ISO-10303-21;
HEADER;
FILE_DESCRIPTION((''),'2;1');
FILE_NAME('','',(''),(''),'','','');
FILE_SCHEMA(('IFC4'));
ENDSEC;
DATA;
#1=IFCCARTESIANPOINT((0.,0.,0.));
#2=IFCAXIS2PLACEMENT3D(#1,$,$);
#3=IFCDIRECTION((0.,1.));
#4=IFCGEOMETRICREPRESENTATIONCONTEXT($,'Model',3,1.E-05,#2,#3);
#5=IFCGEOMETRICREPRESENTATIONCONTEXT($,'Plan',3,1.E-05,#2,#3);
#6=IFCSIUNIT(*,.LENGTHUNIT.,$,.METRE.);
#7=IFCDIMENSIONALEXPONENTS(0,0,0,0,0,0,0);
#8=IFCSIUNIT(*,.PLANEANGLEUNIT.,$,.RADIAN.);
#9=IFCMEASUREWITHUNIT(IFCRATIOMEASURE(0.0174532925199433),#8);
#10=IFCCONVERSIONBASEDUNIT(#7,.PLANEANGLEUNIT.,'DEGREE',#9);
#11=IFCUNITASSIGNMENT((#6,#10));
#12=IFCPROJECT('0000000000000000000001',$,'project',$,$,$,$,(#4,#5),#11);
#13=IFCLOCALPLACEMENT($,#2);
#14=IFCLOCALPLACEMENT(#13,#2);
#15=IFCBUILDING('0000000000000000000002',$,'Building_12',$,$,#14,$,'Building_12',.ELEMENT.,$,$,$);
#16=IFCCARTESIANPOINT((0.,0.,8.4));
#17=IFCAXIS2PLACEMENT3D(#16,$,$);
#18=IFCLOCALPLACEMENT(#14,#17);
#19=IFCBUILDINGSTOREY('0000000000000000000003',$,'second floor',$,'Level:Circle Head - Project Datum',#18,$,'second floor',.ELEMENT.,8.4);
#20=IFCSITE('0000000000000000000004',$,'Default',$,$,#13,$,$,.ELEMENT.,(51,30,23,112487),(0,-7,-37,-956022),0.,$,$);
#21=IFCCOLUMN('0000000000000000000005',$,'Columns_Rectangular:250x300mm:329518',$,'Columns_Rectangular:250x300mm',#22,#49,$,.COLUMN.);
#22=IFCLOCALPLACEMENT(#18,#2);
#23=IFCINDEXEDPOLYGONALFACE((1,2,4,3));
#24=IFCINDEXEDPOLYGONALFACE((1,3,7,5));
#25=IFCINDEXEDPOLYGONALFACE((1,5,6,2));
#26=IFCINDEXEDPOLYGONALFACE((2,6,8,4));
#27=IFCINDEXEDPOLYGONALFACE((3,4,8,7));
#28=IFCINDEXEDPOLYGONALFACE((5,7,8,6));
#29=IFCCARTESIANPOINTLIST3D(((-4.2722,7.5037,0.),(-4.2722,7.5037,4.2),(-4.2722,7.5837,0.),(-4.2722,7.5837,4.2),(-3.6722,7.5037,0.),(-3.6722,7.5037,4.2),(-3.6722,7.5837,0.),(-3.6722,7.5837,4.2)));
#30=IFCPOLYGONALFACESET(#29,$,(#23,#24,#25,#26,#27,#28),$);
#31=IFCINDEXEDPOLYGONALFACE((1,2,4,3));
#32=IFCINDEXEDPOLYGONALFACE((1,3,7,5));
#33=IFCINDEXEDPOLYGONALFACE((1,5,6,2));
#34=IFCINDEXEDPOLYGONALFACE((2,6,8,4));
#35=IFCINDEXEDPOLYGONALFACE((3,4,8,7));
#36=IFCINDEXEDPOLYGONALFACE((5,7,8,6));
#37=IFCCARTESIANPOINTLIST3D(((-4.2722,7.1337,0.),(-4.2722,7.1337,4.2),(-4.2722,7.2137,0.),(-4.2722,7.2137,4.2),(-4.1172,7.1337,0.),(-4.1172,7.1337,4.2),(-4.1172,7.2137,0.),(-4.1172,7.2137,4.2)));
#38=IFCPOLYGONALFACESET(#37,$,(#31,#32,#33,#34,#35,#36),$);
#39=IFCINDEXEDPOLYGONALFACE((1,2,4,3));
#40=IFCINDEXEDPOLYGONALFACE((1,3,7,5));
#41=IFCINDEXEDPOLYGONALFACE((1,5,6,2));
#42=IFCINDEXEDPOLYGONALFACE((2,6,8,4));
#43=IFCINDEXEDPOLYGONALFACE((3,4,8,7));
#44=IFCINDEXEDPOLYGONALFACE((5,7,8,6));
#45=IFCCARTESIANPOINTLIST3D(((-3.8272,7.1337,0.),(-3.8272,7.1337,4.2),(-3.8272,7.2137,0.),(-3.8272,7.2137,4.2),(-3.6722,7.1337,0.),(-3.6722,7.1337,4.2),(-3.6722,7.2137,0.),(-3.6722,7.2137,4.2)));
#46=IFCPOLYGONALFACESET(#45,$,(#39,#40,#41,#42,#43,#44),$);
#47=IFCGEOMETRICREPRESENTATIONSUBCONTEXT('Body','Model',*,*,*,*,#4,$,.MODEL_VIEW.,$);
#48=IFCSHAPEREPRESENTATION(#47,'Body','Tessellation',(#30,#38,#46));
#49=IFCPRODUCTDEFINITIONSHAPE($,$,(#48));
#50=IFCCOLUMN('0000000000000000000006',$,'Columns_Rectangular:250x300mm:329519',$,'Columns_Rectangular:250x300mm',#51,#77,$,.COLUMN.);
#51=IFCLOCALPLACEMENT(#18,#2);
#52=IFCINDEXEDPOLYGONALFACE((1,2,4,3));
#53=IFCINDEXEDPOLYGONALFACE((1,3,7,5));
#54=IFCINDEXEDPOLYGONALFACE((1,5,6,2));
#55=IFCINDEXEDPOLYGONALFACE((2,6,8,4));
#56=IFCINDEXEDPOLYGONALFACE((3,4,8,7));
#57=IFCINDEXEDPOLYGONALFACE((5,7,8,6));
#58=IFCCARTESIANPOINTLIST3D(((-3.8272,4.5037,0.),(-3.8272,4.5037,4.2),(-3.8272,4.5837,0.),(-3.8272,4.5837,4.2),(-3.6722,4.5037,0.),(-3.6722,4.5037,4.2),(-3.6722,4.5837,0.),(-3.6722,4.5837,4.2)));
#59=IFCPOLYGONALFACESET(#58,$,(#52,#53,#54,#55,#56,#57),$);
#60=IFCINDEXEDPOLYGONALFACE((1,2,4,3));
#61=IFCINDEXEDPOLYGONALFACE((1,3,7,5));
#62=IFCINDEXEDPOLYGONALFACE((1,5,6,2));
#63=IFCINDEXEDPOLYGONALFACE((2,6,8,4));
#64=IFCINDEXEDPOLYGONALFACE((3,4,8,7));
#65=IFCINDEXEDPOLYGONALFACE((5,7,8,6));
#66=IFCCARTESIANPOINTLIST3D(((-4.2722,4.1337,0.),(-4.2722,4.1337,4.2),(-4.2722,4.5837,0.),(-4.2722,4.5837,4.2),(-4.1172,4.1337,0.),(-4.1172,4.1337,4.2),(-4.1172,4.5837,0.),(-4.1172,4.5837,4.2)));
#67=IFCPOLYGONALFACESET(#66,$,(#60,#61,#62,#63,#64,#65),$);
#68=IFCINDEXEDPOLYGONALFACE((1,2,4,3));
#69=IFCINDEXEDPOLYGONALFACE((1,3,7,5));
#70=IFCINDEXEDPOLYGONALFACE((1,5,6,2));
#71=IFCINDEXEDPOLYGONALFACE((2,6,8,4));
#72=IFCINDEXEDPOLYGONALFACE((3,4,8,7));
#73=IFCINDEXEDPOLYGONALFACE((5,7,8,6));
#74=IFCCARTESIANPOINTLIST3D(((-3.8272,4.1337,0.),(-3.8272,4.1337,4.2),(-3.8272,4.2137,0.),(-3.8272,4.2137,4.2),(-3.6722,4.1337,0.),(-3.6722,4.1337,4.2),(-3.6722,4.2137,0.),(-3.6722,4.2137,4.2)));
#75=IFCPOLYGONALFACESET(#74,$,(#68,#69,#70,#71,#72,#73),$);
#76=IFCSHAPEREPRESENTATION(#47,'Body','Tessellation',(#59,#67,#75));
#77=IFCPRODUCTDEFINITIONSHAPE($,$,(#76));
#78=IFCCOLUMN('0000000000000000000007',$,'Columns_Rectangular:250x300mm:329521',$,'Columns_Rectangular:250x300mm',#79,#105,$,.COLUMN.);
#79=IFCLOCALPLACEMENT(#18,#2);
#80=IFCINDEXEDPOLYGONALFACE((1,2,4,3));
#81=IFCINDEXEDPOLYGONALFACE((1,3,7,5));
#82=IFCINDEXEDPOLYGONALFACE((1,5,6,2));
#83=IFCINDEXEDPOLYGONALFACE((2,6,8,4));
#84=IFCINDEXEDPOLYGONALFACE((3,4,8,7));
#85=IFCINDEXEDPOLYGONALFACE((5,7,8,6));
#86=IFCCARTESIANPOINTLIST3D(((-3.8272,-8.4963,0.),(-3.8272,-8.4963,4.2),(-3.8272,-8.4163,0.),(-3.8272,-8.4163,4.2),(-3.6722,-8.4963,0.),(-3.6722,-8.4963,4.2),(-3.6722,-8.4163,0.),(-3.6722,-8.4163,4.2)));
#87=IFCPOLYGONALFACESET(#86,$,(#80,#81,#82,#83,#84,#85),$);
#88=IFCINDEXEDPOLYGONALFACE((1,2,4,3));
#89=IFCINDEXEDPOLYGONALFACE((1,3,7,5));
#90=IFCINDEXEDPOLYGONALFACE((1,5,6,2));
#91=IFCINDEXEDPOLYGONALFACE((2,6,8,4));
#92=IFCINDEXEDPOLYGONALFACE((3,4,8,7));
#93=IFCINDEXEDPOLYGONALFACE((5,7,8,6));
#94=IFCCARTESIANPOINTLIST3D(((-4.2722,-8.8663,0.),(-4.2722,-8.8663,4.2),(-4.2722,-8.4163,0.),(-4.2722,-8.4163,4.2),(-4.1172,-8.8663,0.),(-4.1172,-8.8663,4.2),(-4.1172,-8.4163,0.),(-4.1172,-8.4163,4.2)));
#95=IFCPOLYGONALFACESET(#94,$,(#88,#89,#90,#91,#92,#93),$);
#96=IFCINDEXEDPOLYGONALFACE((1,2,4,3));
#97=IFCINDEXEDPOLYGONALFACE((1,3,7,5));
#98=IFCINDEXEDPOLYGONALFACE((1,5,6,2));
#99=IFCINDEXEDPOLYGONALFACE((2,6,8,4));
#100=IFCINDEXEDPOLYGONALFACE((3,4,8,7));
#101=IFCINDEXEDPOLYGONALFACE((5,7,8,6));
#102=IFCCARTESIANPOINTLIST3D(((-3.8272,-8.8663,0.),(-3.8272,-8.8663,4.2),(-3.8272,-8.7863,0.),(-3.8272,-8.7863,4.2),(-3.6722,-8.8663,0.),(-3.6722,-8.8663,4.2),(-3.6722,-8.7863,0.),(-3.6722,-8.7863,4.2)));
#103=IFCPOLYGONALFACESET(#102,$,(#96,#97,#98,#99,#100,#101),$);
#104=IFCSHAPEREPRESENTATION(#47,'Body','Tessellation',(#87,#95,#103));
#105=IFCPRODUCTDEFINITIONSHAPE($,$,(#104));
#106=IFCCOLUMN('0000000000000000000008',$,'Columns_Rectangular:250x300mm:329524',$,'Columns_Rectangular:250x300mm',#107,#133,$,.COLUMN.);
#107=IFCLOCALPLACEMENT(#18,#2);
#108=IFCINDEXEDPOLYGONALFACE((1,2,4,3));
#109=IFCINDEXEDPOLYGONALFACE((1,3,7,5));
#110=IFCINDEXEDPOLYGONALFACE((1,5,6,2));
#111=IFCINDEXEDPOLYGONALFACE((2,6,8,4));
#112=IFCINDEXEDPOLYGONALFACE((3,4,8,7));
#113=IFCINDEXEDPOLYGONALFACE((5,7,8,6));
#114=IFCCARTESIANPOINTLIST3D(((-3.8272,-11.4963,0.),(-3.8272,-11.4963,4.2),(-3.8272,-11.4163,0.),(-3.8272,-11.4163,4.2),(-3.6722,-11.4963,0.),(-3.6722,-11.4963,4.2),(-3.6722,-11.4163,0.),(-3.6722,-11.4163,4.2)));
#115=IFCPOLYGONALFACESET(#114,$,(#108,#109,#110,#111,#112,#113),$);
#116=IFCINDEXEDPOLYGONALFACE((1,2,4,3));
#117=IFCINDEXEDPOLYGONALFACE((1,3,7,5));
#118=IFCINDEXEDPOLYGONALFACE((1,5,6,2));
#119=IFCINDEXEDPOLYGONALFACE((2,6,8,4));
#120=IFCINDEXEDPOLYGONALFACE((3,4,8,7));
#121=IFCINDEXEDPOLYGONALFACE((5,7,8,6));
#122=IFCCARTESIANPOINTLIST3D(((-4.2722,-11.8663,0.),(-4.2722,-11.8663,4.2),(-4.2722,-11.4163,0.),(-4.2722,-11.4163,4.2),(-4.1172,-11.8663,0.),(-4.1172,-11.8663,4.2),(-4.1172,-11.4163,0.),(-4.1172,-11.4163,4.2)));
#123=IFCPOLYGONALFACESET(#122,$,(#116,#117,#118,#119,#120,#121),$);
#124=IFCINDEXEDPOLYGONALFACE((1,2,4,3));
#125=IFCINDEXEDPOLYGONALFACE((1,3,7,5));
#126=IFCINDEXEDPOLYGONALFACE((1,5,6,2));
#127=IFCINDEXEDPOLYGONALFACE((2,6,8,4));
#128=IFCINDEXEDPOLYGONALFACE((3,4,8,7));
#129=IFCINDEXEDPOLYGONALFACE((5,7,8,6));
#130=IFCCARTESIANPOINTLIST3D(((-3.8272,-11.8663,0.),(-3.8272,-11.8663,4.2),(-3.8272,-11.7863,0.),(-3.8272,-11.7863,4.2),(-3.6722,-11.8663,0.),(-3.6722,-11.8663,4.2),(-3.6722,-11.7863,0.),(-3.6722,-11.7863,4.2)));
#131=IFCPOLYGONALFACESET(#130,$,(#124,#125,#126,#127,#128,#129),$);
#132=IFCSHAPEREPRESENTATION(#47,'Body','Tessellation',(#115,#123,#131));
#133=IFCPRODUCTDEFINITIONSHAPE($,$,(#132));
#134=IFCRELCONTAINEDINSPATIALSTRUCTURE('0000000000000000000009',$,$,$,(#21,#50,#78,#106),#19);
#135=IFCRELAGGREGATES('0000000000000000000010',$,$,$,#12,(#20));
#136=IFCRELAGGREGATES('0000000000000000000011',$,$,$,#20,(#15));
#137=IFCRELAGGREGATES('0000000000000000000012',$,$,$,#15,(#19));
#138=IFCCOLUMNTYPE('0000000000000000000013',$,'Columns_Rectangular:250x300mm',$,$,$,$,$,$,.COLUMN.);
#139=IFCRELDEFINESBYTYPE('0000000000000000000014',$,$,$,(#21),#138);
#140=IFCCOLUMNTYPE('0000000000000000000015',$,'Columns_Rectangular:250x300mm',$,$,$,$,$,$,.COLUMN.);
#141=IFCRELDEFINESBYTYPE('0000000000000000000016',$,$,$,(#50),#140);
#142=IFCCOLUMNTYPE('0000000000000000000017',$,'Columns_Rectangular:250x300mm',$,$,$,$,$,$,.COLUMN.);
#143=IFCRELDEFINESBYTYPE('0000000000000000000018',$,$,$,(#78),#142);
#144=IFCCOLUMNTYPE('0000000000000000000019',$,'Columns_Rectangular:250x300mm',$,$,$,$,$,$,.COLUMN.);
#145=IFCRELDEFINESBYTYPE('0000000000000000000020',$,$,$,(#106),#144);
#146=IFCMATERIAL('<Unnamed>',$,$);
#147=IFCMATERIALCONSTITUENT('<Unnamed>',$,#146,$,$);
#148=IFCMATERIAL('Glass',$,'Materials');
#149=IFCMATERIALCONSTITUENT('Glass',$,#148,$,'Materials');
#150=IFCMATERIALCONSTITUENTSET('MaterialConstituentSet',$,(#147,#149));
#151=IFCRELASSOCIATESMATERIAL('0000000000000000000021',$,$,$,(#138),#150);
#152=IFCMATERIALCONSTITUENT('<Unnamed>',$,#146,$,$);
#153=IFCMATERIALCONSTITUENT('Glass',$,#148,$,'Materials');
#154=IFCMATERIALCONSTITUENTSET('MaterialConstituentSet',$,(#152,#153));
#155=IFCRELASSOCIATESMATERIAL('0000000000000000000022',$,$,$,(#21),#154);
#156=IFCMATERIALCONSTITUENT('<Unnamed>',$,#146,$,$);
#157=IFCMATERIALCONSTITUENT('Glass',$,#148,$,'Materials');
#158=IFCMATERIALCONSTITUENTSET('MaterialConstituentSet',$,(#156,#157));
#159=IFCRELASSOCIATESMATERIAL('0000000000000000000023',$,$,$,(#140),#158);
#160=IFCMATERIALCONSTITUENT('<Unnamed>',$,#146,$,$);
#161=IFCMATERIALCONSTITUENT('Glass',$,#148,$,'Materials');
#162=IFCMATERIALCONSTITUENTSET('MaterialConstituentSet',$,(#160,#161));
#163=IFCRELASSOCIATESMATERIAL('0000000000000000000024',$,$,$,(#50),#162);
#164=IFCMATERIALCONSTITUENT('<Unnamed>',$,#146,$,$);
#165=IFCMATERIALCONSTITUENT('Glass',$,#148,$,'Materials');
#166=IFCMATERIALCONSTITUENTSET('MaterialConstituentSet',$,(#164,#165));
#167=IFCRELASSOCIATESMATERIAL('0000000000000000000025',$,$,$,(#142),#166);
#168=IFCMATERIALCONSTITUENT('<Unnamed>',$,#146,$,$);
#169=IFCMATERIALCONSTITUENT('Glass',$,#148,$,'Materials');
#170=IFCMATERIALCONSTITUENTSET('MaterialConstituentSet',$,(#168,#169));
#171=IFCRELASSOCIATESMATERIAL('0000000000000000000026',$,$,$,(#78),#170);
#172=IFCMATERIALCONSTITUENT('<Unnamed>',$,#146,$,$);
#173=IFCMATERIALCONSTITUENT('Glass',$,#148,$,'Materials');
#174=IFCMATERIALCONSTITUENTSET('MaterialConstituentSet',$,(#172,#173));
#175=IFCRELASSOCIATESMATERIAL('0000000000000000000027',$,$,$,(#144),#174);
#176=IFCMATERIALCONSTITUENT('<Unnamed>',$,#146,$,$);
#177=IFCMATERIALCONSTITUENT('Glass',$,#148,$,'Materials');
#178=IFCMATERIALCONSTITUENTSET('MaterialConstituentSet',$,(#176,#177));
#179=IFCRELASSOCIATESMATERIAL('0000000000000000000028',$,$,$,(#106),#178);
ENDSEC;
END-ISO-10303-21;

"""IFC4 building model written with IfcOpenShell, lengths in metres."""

from ifc_helpers import new_model, entity, si_unit, converted_unit, direction, frame, origin, place, context, subcontext, project, spatial, indexed_curve, outline, extrude, source, transform, mapped, material, constituent, constituent_set, type_object, type_shapes, element, save


model = new_model("IFC4")

# Units and contexts
model_context = context("Model", 3, precision=1e-05, world=origin(), true_north=direction((0.0, 1.0)))
plan_context = context("Plan", 3, precision=1e-05, world=origin(), true_north=direction((0.0, 1.0)))
body_context = subcontext(model_context, "Body", "Model", "MODEL_VIEW")
ifc_project = project(units=[si_unit("LENGTHUNIT", "METRE"), converted_unit("PLANEANGLEUNIT", "DEGREE", entity("IfcRatioMeasure", 0.0174532925199433), si_unit("PLANEANGLEUNIT", "RADIAN"), dimensions=[0, 0, 0, 0, 0, 0, 0])], contexts=[model_context, plan_context])

# Site, building, storey
site_placement = place(None, origin())
site = spatial("IfcSite", under=ifc_project, at=site_placement, Name="Default", CompositionType="ELEMENT", RefLatitude=(51, 30, 23, 112487), RefLongitude=(0, -7, -37, -956022), RefElevation=0.0)
building_placement = place(site_placement, origin())
building = spatial("IfcBuilding", under=site, at=building_placement, Name="Building_12", LongName="Building_12", CompositionType="ELEMENT")
storey_placement = place(building_placement, frame((0.0, 0.0, 8.4)))
storey = spatial("IfcBuildingStorey", under=building, at=storey_placement, Name="second floor", ObjectType="Level:Circle Head - Project Datum", LongName="second floor", CompositionType="ELEMENT", Elevation=8.4)

# Columns
ifc_material_1 = material(Name="<Unnamed>")
ifc_constituent_1 = constituent(ifc_material_1, Name="<Unnamed>")
ifc_material_2 = material(Name="Glass", Category="Materials")
ifc_constituent_2 = constituent(ifc_material_2, Name="Glass", Category="Materials")
ifc_constituent_set_1 = constituent_set(constituents=[ifc_constituent_1, ifc_constituent_2], Name="MaterialConstituentSet")
ifc_constituent_3 = constituent(ifc_material_1, Name="<Unnamed>")
ifc_constituent_4 = constituent(ifc_material_2, Name="Glass", Category="Materials")
ifc_constituent_set_2 = constituent_set(constituents=[ifc_constituent_3, ifc_constituent_4], Name="MaterialConstituentSet")
column_type_1 = type_object("IfcColumnType", Name="Columns_Rectangular:250x300mm", PredefinedType="COLUMN", material=ifc_constituent_set_2)
shared_shape_1 = source(origin(), body_context, "Body", "SweptSolid", [
    extrude(outline(indexed_curve([(-0.04, -0.3), (0.04, -0.3), (0.04, 0.3), (-0.04, 0.3), (-0.04, -0.3)], self_intersect=False)), frame((-3.9722, 7.5437, 8.4), z_axis=(0.0, 0.0, 1.0), x_axis=(0.0, -1.0, 0.0)), (0.0, 0.0, 1.0), 4.2),
    extrude(outline(indexed_curve([(-0.04, -0.0775), (0.04, -0.0775), (0.04, 0.0775), (-0.04, 0.0775), (-0.04, -0.0775)], self_intersect=False)), frame((-4.1947, 7.1737, 8.4), z_axis=(0.0, 0.0, 1.0), x_axis=(0.0, -1.0, 0.0)), (0.0, 0.0, 1.0), 4.2),
    extrude(outline(indexed_curve([(-0.04, -0.0775), (0.04, -0.0775), (0.04, 0.0775), (-0.04, 0.0775), (-0.04, -0.0775)], self_intersect=False)), frame((-3.7497, 7.1737, 8.4), z_axis=(0.0, 0.0, 1.0), x_axis=(0.0, -1.0, 0.0)), (0.0, 0.0, 1.0), 4.2),
])
type_shapes(column_type_1, [shared_shape_1])
column_1_placement = place(storey_placement, frame((0.0, 0.0, -8.4)))
element("IfcColumn", 1, at=column_1_placement, inside=storey, type_object=column_type_1, material=ifc_constituent_set_1, Name="Columns_Rectangular:250x300mm:329518", ObjectType="Columns_Rectangular:250x300mm", PredefinedType="COLUMN", context=body_context, shape_type="MappedRepresentation", body=[
    mapped(shared_shape_1, transform((0.0, 0.0, 0.0), scale=1.0)),
])
ifc_constituent_5 = constituent(ifc_material_1, Name="<Unnamed>")
ifc_constituent_6 = constituent(ifc_material_2, Name="Glass", Category="Materials")
ifc_constituent_set_3 = constituent_set(constituents=[ifc_constituent_5, ifc_constituent_6], Name="MaterialConstituentSet")
ifc_constituent_7 = constituent(ifc_material_1, Name="<Unnamed>")
ifc_constituent_8 = constituent(ifc_material_2, Name="Glass", Category="Materials")
ifc_constituent_set_4 = constituent_set(constituents=[ifc_constituent_7, ifc_constituent_8], Name="MaterialConstituentSet")
column_type_2 = type_object("IfcColumnType", Name="Columns_Rectangular:250x300mm", PredefinedType="COLUMN", material=ifc_constituent_set_4)
shared_shape_2 = source(origin(), body_context, "Body", "SweptSolid", [
    extrude(outline(indexed_curve([(-0.04, -0.0775), (0.04, -0.0775), (0.04, 0.0775), (-0.04, 0.0775), (-0.04, -0.0775)], self_intersect=False)), frame((-3.7497, 4.5437, 8.4), z_axis=(0.0, 0.0, 1.0), x_axis=(0.0, -1.0, 0.0)), (0.0, 0.0, 1.0), 4.2),
    extrude(outline(indexed_curve([(-0.225, -0.0775), (0.225, -0.0775), (0.225, 0.0775), (-0.225, 0.0775), (-0.225, -0.0775)], self_intersect=False)), frame((-4.1947, 4.3587, 8.4), z_axis=(0.0, 0.0, 1.0), x_axis=(0.0, -1.0, 0.0)), (0.0, 0.0, 1.0), 4.2),
    extrude(outline(indexed_curve([(-0.04, -0.0775), (0.04, -0.0775), (0.04, 0.0775), (-0.04, 0.0775), (-0.04, -0.0775)], self_intersect=False)), frame((-3.7497, 4.1737, 8.4), z_axis=(0.0, 0.0, 1.0), x_axis=(0.0, -1.0, 0.0)), (0.0, 0.0, 1.0), 4.2),
])
type_shapes(column_type_2, [shared_shape_2])
column_2_placement = place(storey_placement, frame((0.0, 0.0, -8.4)))
element("IfcColumn", 2, at=column_2_placement, inside=storey, type_object=column_type_2, material=ifc_constituent_set_3, Name="Columns_Rectangular:250x300mm:329519", ObjectType="Columns_Rectangular:250x300mm", PredefinedType="COLUMN", context=body_context, shape_type="MappedRepresentation", body=[
    mapped(shared_shape_2, transform((0.0, 0.0, 0.0), scale=1.0)),
])
ifc_constituent_9 = constituent(ifc_material_1, Name="<Unnamed>")
ifc_constituent_10 = constituent(ifc_material_2, Name="Glass", Category="Materials")
ifc_constituent_set_5 = constituent_set(constituents=[ifc_constituent_9, ifc_constituent_10], Name="MaterialConstituentSet")
ifc_constituent_11 = constituent(ifc_material_1, Name="<Unnamed>")
ifc_constituent_12 = constituent(ifc_material_2, Name="Glass", Category="Materials")
ifc_constituent_set_6 = constituent_set(constituents=[ifc_constituent_11, ifc_constituent_12], Name="MaterialConstituentSet")
column_type_3 = type_object("IfcColumnType", Name="Columns_Rectangular:250x300mm", PredefinedType="COLUMN", material=ifc_constituent_set_6)
shared_shape_3 = source(origin(), body_context, "Body", "SweptSolid", [
    extrude(outline(indexed_curve([(-0.04, -0.0775), (0.04, -0.0775), (0.04, 0.0775), (-0.04, 0.0775), (-0.04, -0.0775)], self_intersect=False)), frame((-3.7497, -8.4563, 8.4), z_axis=(0.0, 0.0, 1.0), x_axis=(0.0, -1.0, 0.0)), (0.0, 0.0, 1.0), 4.2),
    extrude(outline(indexed_curve([(-0.225, -0.0775), (0.225, -0.0775), (0.225, 0.0775), (-0.225, 0.0775), (-0.225, -0.0775)], self_intersect=False)), frame((-4.1947, -8.6413, 8.4), z_axis=(0.0, 0.0, 1.0), x_axis=(0.0, -1.0, 0.0)), (0.0, 0.0, 1.0), 4.2),
    extrude(outline(indexed_curve([(-0.04, -0.0775), (0.04, -0.0775), (0.04, 0.0775), (-0.04, 0.0775), (-0.04, -0.0775)], self_intersect=False)), frame((-3.7497, -8.8263, 8.4), z_axis=(0.0, 0.0, 1.0), x_axis=(0.0, -1.0, 0.0)), (0.0, 0.0, 1.0), 4.2),
])
type_shapes(column_type_3, [shared_shape_3])
column_3_placement = place(storey_placement, frame((0.0, 0.0, -8.4)))
element("IfcColumn", 3, at=column_3_placement, inside=storey, type_object=column_type_3, material=ifc_constituent_set_5, Name="Columns_Rectangular:250x300mm:329521", ObjectType="Columns_Rectangular:250x300mm", PredefinedType="COLUMN", context=body_context, shape_type="MappedRepresentation", body=[
    mapped(shared_shape_3, transform((0.0, 0.0, 0.0), scale=1.0)),
])
ifc_constituent_13 = constituent(ifc_material_1, Name="<Unnamed>")
ifc_constituent_14 = constituent(ifc_material_2, Name="Glass", Category="Materials")
ifc_constituent_set_7 = constituent_set(constituents=[ifc_constituent_13, ifc_constituent_14], Name="MaterialConstituentSet")
ifc_constituent_15 = constituent(ifc_material_1, Name="<Unnamed>")
ifc_constituent_16 = constituent(ifc_material_2, Name="Glass", Category="Materials")
ifc_constituent_set_8 = constituent_set(constituents=[ifc_constituent_15, ifc_constituent_16], Name="MaterialConstituentSet")
column_type_4 = type_object("IfcColumnType", Name="Columns_Rectangular:250x300mm", PredefinedType="COLUMN", material=ifc_constituent_set_8)
shared_shape_4 = source(origin(), body_context, "Body", "SweptSolid", [
    extrude(outline(indexed_curve([(-0.04, -0.0775), (0.04, -0.0775), (0.04, 0.0775), (-0.04, 0.0775), (-0.04, -0.0775)], self_intersect=False)), frame((-3.7497, -11.4563, 8.4), z_axis=(0.0, 0.0, 1.0), x_axis=(0.0, -1.0, 0.0)), (0.0, 0.0, 1.0), 4.2),
    extrude(outline(indexed_curve([(-0.225, -0.0775), (0.225, -0.0775), (0.225, 0.0775), (-0.225, 0.0775), (-0.225, -0.0775)], self_intersect=False)), frame((-4.1947, -11.6413, 8.4), z_axis=(0.0, 0.0, 1.0), x_axis=(0.0, -1.0, 0.0)), (0.0, 0.0, 1.0), 4.2),
    extrude(outline(indexed_curve([(-0.04, -0.0775), (0.04, -0.0775), (0.04, 0.0775), (-0.04, 0.0775), (-0.04, -0.0775)], self_intersect=False)), frame((-3.7497, -11.8263, 8.4), z_axis=(0.0, 0.0, 1.0), x_axis=(0.0, -1.0, 0.0)), (0.0, 0.0, 1.0), 4.2),
])
type_shapes(column_type_4, [shared_shape_4])
column_4_placement = place(storey_placement, frame((0.0, 0.0, -8.4)))
element("IfcColumn", 4, at=column_4_placement, inside=storey, type_object=column_type_4, material=ifc_constituent_set_7, Name="Columns_Rectangular:250x300mm:329524", ObjectType="Columns_Rectangular:250x300mm", PredefinedType="COLUMN", context=body_context, shape_type="MappedRepresentation", body=[
    mapped(shared_shape_4, transform((0.0, 0.0, 0.0), scale=1.0)),
])

save(model, "model.ifc")
